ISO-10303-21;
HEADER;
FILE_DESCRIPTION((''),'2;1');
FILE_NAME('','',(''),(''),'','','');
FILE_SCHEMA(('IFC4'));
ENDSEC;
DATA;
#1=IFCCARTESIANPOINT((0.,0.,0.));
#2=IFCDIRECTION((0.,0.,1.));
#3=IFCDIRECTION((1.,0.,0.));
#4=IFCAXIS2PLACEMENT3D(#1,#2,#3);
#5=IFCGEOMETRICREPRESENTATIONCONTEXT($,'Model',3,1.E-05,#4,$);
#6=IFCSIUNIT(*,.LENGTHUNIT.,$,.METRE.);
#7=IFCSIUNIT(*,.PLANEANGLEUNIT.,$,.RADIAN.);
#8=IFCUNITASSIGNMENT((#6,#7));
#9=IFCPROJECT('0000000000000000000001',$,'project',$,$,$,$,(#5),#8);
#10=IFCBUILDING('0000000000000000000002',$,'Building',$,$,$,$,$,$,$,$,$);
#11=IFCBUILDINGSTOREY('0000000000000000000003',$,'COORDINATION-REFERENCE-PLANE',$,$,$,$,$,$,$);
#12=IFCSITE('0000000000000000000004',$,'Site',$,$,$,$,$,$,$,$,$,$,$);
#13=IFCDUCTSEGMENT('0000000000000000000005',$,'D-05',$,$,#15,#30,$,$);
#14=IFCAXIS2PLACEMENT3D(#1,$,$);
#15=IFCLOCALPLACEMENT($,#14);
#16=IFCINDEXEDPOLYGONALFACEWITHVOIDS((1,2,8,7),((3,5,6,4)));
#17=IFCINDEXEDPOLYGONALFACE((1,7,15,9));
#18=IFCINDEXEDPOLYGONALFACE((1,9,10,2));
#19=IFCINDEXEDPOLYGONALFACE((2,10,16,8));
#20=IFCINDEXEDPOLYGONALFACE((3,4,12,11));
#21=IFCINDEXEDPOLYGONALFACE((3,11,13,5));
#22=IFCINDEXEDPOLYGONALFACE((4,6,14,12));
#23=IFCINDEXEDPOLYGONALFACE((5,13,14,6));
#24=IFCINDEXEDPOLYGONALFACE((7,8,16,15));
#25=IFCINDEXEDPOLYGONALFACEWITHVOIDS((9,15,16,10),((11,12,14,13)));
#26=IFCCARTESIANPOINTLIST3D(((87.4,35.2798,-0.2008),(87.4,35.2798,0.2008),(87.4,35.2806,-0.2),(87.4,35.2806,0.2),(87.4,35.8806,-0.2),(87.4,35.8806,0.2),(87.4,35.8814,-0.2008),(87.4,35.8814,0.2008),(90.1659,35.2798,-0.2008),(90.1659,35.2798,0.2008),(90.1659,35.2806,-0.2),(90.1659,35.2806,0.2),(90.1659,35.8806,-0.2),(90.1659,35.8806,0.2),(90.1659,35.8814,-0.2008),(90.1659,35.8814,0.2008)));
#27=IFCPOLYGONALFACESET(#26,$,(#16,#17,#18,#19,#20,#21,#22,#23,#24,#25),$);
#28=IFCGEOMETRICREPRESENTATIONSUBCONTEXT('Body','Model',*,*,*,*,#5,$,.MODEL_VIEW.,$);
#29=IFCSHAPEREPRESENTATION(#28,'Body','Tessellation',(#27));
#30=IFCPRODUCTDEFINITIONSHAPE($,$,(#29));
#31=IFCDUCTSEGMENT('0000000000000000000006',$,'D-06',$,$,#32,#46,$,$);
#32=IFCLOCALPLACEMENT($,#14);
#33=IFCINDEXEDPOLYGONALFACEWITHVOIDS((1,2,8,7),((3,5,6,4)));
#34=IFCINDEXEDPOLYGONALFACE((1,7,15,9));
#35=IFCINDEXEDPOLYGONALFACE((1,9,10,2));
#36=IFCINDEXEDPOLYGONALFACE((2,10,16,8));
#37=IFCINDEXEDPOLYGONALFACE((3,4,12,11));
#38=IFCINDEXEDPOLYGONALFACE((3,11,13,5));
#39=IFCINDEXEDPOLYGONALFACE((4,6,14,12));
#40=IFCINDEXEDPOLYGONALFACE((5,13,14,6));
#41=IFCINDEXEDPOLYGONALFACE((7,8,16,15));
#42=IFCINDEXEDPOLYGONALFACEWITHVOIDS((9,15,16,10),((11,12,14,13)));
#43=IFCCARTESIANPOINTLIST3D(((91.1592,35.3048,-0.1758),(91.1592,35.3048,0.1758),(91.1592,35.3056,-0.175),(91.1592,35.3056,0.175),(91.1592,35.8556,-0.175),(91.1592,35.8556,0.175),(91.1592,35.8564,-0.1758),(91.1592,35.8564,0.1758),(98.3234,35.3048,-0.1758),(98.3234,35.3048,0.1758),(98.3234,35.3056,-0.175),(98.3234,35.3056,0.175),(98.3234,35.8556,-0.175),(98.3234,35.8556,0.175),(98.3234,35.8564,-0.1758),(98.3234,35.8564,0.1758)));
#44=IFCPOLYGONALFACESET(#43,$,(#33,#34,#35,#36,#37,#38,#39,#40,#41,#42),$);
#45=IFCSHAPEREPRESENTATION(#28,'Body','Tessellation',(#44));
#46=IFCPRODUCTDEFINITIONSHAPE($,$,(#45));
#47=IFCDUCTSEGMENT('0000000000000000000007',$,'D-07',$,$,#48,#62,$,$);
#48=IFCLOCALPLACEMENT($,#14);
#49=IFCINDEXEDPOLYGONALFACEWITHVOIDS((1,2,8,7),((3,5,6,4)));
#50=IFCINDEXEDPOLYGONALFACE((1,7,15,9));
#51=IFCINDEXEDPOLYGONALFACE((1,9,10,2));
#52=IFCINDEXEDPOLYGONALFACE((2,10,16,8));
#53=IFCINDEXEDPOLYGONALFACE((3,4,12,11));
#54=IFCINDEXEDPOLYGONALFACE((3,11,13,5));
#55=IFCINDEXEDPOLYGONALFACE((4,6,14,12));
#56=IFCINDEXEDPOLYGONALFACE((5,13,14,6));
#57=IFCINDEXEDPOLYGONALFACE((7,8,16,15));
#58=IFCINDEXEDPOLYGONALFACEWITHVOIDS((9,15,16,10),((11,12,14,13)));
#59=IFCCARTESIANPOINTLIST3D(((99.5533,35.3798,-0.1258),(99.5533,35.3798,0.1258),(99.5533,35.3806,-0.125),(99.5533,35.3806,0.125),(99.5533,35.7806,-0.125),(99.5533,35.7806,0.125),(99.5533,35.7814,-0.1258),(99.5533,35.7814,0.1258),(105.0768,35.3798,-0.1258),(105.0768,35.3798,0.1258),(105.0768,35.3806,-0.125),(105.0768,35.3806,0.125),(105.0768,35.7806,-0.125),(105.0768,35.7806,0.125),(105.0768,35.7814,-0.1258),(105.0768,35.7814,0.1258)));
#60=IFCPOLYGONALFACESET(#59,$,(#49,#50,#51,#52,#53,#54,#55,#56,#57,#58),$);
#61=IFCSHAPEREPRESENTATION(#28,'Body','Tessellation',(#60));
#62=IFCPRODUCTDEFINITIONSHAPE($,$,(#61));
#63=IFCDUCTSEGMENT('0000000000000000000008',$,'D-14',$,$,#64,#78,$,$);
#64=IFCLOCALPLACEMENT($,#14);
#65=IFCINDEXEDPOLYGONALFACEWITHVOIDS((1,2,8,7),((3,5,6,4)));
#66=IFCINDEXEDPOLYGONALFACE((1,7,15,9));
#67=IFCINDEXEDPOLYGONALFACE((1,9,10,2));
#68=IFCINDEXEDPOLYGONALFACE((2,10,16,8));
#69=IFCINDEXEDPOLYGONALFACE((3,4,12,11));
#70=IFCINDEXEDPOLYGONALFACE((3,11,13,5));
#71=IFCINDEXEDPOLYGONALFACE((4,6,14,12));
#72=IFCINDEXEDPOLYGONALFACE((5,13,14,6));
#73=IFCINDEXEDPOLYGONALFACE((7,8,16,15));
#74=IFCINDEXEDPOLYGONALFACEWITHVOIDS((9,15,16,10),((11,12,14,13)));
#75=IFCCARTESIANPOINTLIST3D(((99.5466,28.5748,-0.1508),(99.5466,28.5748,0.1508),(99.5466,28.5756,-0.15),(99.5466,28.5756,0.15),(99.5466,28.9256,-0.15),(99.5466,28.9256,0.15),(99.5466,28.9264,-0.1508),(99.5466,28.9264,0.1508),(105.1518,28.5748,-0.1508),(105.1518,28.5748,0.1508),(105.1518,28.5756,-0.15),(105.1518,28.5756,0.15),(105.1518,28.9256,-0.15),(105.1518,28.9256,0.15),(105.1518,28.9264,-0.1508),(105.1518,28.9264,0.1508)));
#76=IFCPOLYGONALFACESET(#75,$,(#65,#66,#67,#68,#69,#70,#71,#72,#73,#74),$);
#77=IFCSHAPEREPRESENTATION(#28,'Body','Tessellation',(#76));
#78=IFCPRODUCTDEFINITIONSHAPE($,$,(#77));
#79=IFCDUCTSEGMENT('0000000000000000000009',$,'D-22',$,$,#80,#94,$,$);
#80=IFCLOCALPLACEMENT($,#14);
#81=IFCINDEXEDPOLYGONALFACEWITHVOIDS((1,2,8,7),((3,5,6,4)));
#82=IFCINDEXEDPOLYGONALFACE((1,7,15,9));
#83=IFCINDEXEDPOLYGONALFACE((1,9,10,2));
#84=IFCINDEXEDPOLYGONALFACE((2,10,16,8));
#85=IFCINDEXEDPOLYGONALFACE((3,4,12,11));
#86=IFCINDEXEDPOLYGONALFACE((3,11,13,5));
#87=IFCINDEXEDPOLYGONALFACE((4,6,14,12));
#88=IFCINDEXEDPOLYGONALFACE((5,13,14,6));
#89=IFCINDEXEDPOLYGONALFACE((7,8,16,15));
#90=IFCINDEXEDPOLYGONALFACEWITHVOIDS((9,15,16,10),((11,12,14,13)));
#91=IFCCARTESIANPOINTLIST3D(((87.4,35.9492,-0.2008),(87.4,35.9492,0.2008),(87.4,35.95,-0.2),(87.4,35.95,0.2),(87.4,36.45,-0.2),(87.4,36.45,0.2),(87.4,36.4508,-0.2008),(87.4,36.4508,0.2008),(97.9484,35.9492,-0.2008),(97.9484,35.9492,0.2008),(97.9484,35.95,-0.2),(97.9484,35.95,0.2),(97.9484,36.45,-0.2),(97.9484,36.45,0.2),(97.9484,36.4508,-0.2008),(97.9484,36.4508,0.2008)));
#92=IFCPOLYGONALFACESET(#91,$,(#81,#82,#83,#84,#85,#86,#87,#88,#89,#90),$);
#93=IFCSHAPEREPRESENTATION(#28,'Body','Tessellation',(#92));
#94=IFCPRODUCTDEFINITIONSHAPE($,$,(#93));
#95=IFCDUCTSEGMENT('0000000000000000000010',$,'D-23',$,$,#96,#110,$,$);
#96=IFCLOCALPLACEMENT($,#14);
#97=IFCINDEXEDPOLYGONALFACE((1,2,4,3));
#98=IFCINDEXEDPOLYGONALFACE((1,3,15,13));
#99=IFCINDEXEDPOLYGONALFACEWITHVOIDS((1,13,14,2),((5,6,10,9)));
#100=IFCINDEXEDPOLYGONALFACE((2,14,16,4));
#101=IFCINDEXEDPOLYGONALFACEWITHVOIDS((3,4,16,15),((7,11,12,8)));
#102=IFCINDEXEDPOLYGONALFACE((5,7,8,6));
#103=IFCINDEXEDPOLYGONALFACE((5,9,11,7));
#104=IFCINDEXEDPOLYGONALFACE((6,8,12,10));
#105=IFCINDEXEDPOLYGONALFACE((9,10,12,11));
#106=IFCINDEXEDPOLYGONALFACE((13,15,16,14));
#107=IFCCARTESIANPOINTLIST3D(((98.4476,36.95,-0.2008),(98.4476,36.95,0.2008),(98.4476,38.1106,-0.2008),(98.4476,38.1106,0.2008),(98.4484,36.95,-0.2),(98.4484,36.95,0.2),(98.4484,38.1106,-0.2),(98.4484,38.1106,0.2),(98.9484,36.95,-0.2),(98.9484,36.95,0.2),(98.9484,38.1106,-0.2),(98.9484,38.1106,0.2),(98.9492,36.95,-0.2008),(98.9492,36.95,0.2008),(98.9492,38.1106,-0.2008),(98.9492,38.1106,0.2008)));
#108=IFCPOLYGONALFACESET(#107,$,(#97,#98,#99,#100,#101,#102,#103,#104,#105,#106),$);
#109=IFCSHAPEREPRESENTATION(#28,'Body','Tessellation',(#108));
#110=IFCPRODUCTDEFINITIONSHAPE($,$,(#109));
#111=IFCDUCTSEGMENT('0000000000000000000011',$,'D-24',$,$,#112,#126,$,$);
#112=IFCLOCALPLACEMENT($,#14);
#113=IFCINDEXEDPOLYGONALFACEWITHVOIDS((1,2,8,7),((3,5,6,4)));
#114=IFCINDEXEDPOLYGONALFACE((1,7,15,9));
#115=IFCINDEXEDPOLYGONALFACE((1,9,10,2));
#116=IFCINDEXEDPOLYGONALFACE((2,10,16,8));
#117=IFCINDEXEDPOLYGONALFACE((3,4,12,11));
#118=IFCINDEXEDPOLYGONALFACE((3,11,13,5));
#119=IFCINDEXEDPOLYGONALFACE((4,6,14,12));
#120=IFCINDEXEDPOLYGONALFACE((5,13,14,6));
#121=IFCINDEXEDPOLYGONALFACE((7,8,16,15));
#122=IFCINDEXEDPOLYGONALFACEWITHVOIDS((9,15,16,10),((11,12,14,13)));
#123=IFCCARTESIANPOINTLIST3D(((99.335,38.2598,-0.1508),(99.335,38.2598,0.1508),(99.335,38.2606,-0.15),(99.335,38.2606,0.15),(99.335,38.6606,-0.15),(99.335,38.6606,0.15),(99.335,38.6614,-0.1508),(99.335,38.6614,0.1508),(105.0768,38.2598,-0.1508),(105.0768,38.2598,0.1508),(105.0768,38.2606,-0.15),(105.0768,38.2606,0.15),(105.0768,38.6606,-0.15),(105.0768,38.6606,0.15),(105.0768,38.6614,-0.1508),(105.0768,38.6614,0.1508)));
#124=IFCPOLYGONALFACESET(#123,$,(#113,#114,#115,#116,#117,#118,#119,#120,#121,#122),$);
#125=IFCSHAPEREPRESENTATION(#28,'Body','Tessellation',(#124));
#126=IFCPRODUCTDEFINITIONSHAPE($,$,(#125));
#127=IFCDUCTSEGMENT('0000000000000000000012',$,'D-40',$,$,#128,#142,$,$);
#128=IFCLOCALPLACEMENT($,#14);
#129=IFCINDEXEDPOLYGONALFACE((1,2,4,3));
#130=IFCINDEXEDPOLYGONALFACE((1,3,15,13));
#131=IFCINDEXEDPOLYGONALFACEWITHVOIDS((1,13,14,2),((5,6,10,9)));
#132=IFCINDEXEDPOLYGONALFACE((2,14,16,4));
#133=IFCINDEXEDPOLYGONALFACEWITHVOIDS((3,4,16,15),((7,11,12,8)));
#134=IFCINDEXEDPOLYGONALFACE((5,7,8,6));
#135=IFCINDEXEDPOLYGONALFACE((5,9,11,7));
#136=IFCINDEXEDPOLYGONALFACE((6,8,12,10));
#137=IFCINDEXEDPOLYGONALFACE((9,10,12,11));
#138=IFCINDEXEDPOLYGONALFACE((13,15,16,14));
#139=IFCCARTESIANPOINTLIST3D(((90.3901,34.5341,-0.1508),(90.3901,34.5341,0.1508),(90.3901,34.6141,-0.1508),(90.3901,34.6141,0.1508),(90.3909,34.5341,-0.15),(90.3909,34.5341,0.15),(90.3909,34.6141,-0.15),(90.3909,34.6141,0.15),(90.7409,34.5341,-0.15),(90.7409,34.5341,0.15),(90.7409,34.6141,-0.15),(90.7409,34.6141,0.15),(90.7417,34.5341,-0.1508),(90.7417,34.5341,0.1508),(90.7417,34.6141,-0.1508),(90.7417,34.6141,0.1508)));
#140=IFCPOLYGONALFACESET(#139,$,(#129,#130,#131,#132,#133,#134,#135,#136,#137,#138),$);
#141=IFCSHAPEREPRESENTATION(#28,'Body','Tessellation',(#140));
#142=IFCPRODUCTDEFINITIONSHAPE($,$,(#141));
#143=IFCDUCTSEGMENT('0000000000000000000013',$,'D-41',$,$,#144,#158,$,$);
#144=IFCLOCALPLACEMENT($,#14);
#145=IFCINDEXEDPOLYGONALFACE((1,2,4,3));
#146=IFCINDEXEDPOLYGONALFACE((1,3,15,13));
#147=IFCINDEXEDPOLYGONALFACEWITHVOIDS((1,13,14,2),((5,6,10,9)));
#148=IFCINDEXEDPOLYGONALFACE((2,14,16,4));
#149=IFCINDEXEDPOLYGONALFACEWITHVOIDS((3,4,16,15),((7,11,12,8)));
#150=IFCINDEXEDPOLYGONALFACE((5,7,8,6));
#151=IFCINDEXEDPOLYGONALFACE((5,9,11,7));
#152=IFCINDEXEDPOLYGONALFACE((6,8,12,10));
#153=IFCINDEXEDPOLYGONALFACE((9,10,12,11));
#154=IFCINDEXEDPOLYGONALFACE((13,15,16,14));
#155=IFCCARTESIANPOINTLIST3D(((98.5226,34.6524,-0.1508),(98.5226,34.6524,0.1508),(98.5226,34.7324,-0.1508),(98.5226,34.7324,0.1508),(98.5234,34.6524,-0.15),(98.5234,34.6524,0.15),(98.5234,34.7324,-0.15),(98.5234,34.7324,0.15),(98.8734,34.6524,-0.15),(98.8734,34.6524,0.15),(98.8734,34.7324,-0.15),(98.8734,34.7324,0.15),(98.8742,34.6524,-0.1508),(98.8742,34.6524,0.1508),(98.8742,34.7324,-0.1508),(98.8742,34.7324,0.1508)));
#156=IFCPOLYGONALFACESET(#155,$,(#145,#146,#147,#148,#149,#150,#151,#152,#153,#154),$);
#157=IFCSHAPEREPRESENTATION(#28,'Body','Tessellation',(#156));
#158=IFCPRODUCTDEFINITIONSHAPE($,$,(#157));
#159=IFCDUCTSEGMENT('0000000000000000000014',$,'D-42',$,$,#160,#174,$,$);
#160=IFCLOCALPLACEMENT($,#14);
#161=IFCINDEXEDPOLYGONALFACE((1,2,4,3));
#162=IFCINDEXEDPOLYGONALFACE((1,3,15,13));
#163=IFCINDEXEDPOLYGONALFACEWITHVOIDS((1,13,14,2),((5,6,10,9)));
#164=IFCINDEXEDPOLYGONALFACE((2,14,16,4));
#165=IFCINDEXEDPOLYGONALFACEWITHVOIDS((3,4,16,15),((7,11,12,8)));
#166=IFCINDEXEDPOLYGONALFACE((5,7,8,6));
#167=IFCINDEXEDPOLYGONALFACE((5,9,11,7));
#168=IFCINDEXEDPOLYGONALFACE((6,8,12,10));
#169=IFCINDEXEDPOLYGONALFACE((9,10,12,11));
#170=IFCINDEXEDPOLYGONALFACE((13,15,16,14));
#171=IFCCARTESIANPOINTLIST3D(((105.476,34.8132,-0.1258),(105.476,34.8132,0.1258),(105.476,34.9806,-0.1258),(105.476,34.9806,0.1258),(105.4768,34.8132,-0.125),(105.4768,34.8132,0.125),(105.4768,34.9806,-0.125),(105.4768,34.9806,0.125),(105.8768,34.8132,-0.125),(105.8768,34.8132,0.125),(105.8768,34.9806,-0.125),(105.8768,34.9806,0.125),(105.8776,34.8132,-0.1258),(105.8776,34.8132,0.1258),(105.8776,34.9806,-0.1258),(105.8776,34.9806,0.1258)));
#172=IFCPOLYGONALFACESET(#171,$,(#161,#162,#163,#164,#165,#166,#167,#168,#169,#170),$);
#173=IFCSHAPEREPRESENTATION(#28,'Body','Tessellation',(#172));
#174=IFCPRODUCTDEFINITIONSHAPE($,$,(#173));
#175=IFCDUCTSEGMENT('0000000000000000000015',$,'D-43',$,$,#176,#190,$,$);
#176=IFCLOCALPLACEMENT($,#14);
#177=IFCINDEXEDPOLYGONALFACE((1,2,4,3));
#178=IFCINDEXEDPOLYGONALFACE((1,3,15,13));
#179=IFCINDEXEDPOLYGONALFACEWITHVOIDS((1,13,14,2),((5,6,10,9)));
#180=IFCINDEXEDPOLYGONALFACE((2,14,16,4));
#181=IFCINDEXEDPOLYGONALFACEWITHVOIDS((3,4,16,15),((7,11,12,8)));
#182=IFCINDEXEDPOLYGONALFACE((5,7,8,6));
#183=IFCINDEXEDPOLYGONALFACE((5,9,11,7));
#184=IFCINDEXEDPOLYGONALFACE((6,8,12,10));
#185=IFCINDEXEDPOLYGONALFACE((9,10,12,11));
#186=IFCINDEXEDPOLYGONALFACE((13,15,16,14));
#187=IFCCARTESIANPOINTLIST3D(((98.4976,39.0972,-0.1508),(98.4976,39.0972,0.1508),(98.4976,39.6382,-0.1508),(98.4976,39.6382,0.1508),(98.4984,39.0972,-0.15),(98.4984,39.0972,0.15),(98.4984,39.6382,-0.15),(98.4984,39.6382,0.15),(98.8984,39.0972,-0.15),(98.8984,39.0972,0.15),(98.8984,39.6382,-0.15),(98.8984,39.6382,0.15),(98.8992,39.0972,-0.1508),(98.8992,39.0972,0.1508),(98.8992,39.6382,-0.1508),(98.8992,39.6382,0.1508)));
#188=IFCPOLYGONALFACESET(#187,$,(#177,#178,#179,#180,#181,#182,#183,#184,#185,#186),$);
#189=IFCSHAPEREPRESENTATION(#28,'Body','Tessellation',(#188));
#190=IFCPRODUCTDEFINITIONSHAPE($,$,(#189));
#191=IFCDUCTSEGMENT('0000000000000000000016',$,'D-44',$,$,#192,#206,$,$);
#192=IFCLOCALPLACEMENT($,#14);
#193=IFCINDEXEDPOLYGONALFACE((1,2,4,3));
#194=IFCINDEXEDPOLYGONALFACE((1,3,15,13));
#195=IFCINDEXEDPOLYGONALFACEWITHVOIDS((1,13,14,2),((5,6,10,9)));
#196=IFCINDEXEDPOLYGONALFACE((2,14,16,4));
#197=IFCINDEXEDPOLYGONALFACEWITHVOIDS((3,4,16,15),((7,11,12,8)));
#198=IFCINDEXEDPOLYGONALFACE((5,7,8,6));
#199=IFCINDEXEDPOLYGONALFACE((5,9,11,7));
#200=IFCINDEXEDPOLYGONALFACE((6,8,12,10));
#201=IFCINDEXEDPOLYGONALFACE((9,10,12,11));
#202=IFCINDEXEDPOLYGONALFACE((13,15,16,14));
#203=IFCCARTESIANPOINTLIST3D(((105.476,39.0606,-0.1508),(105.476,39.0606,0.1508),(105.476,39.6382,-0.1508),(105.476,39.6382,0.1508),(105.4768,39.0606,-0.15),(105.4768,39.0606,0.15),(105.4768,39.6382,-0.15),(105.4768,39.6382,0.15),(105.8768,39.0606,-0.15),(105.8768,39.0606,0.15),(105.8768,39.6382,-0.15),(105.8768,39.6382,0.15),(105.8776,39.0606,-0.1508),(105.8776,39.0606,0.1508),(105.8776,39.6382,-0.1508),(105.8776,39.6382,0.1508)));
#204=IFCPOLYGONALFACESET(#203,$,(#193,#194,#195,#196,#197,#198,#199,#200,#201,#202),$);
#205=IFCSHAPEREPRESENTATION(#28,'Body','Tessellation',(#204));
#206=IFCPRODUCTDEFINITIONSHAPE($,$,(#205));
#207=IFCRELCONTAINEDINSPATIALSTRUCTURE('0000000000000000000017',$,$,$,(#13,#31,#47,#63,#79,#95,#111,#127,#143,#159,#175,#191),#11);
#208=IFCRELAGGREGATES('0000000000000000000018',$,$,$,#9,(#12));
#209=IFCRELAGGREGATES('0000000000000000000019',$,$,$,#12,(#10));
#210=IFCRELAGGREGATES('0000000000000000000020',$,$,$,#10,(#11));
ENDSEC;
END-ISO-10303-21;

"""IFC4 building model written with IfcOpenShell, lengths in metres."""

from ifc_helpers import new_model, si_unit, frame, origin, origin_with_axes, place, context, subcontext, project, spatial, hollow_rectangle, extrude, element, save


model = new_model("IFC4")

# Units and contexts
model_context = context("Model", 3, precision=1e-05, world=origin_with_axes())
body_context_1 = subcontext(model_context, "Body", "Model", "MODEL_VIEW")
ifc_project = project(units=[si_unit("LENGTHUNIT", "METRE"), si_unit("PLANEANGLEUNIT", "RADIAN")], contexts=[model_context])

# Site, building, storey
site = spatial("IfcSite", under=ifc_project, Name="Site")
building = spatial("IfcBuilding", under=site, Name="Building")
storey = spatial("IfcBuildingStorey", under=building, Name="COORDINATION-REFERENCE-PLANE")

# Duct segments
duct_segment_1_placement = place(None, frame((87.4, 35.5806, 0.0), z_axis=(1.0, 0.0, 0.0), x_axis=(0.0, 1.0, 0.0)))
element("IfcDuctSegment", 1, at=duct_segment_1_placement, inside=storey, Name="D-05", context=body_context_1, shape_type="SweptSolid", body=[
    extrude(hollow_rectangle(XDim=0.6016, YDim=0.4016, WallThickness=0.0008), origin(), (0.0, 0.0, 1.0), 2.7659),
])
duct_segment_2_placement = place(None, frame((91.1592, 35.5806, 0.0), z_axis=(1.0, 0.0, 0.0), x_axis=(0.0, 1.0, 0.0)))
element("IfcDuctSegment", 2, at=duct_segment_2_placement, inside=storey, Name="D-06", context=body_context_1, shape_type="SweptSolid", body=[
    extrude(hollow_rectangle(XDim=0.5516, YDim=0.3516, WallThickness=0.0008), origin(), (0.0, 0.0, 1.0), 7.1642),
])
duct_segment_3_placement = place(None, frame((99.5533, 35.5806, 0.0), z_axis=(1.0, 0.0, 0.0), x_axis=(0.0, 1.0, 0.0)))
element("IfcDuctSegment", 3, at=duct_segment_3_placement, inside=storey, Name="D-07", context=body_context_1, shape_type="SweptSolid", body=[
    extrude(hollow_rectangle(XDim=0.4016, YDim=0.2516, WallThickness=0.0008), origin(), (0.0, 0.0, 1.0), 5.5234),
])
duct_segment_4_placement = place(None, frame((99.5466, 28.7506, 0.0), z_axis=(1.0, 0.0, 0.0), x_axis=(0.0, 1.0, 0.0)))
element("IfcDuctSegment", 4, at=duct_segment_4_placement, inside=storey, Name="D-14", context=body_context_1, shape_type="SweptSolid", body=[
    extrude(hollow_rectangle(XDim=0.3516, YDim=0.3016, WallThickness=0.0008), origin(), (0.0, 0.0, 1.0), 5.6051),
])
duct_segment_5_placement = place(None, frame((87.4, 36.2, 0.0), z_axis=(1.0, 0.0, 0.0), x_axis=(0.0, 1.0, 0.0)))
element("IfcDuctSegment", 5, at=duct_segment_5_placement, inside=storey, Name="D-22", context=body_context_1, shape_type="SweptSolid", body=[
    extrude(hollow_rectangle(XDim=0.5016, YDim=0.4016, WallThickness=0.0008), origin(), (0.0, 0.0, 1.0), 10.5484),
])
duct_segment_6_placement = place(None, frame((98.6984, 36.95, 0.0), z_axis=(0.0, 1.0, 0.0), x_axis=(1.0, 0.0, 0.0)))
element("IfcDuctSegment", 6, at=duct_segment_6_placement, inside=storey, Name="D-23", context=body_context_1, shape_type="SweptSolid", body=[
    extrude(hollow_rectangle(XDim=0.5016, YDim=0.4016, WallThickness=0.0008), origin(), (0.0, 0.0, 1.0), 1.1606),
])
duct_segment_7_placement = place(None, frame((99.335, 38.4606, 0.0), z_axis=(1.0, 0.0, 0.0), x_axis=(0.0, 1.0, 0.0)))
element("IfcDuctSegment", 7, at=duct_segment_7_placement, inside=storey, Name="D-24", context=body_context_1, shape_type="SweptSolid", body=[
    extrude(hollow_rectangle(XDim=0.4016, YDim=0.3016, WallThickness=0.0008), origin(), (0.0, 0.0, 1.0), 5.7417),
])
for number, where, z_axis, x_axis, name in (
    (8, (90.5659, 34.5341, 0.0), (0.0, 1.0, 0.0), (1.0, 0.0, 0.0), "D-40"),
    (9, (98.6984, 34.6524, 0.0), (0.0, 1.0, 0.0), (1.0, 0.0, 0.0), "D-41"),
):
    element("IfcDuctSegment", number, at=place(None, frame(where, z_axis=z_axis, x_axis=x_axis)), inside=storey, Name=name, context=body_context_1, shape_type="SweptSolid", body=[
        extrude(hollow_rectangle(XDim=0.3516, YDim=0.3016, WallThickness=0.0008), origin(), (0.0, 0.0, 1.0), 0.08),
    ])
duct_segment_8_placement = place(None, frame((105.6768, 34.8132, 0.0), z_axis=(0.0, 1.0, 0.0), x_axis=(1.0, 0.0, 0.0)))
element("IfcDuctSegment", 10, at=duct_segment_8_placement, inside=storey, Name="D-42", context=body_context_1, shape_type="SweptSolid", body=[
    extrude(hollow_rectangle(XDim=0.4016, YDim=0.2516, WallThickness=0.0008), origin(), (0.0, 0.0, 1.0), 0.1673),
])
duct_segment_9_placement = place(None, frame((98.6984, 39.0972, 0.0), z_axis=(0.0, 1.0, 0.0), x_axis=(1.0, 0.0, 0.0)))
element("IfcDuctSegment", 11, at=duct_segment_9_placement, inside=storey, Name="D-43", context=body_context_1, shape_type="SweptSolid", body=[
    extrude(hollow_rectangle(XDim=0.4016, YDim=0.3016, WallThickness=0.0008), origin(), (0.0, 0.0, 1.0), 0.541),
])
duct_segment_10_placement = place(None, frame((105.6768, 39.0606, 0.0), z_axis=(0.0, 1.0, 0.0), x_axis=(1.0, 0.0, 0.0)))
element("IfcDuctSegment", 12, at=duct_segment_10_placement, inside=storey, Name="D-44", context=body_context_1, shape_type="SweptSolid", body=[
    extrude(hollow_rectangle(XDim=0.4016, YDim=0.3016, WallThickness=0.0008), origin(), (0.0, 0.0, 1.0), 0.5776),
])

save(model, "model.ifc")
